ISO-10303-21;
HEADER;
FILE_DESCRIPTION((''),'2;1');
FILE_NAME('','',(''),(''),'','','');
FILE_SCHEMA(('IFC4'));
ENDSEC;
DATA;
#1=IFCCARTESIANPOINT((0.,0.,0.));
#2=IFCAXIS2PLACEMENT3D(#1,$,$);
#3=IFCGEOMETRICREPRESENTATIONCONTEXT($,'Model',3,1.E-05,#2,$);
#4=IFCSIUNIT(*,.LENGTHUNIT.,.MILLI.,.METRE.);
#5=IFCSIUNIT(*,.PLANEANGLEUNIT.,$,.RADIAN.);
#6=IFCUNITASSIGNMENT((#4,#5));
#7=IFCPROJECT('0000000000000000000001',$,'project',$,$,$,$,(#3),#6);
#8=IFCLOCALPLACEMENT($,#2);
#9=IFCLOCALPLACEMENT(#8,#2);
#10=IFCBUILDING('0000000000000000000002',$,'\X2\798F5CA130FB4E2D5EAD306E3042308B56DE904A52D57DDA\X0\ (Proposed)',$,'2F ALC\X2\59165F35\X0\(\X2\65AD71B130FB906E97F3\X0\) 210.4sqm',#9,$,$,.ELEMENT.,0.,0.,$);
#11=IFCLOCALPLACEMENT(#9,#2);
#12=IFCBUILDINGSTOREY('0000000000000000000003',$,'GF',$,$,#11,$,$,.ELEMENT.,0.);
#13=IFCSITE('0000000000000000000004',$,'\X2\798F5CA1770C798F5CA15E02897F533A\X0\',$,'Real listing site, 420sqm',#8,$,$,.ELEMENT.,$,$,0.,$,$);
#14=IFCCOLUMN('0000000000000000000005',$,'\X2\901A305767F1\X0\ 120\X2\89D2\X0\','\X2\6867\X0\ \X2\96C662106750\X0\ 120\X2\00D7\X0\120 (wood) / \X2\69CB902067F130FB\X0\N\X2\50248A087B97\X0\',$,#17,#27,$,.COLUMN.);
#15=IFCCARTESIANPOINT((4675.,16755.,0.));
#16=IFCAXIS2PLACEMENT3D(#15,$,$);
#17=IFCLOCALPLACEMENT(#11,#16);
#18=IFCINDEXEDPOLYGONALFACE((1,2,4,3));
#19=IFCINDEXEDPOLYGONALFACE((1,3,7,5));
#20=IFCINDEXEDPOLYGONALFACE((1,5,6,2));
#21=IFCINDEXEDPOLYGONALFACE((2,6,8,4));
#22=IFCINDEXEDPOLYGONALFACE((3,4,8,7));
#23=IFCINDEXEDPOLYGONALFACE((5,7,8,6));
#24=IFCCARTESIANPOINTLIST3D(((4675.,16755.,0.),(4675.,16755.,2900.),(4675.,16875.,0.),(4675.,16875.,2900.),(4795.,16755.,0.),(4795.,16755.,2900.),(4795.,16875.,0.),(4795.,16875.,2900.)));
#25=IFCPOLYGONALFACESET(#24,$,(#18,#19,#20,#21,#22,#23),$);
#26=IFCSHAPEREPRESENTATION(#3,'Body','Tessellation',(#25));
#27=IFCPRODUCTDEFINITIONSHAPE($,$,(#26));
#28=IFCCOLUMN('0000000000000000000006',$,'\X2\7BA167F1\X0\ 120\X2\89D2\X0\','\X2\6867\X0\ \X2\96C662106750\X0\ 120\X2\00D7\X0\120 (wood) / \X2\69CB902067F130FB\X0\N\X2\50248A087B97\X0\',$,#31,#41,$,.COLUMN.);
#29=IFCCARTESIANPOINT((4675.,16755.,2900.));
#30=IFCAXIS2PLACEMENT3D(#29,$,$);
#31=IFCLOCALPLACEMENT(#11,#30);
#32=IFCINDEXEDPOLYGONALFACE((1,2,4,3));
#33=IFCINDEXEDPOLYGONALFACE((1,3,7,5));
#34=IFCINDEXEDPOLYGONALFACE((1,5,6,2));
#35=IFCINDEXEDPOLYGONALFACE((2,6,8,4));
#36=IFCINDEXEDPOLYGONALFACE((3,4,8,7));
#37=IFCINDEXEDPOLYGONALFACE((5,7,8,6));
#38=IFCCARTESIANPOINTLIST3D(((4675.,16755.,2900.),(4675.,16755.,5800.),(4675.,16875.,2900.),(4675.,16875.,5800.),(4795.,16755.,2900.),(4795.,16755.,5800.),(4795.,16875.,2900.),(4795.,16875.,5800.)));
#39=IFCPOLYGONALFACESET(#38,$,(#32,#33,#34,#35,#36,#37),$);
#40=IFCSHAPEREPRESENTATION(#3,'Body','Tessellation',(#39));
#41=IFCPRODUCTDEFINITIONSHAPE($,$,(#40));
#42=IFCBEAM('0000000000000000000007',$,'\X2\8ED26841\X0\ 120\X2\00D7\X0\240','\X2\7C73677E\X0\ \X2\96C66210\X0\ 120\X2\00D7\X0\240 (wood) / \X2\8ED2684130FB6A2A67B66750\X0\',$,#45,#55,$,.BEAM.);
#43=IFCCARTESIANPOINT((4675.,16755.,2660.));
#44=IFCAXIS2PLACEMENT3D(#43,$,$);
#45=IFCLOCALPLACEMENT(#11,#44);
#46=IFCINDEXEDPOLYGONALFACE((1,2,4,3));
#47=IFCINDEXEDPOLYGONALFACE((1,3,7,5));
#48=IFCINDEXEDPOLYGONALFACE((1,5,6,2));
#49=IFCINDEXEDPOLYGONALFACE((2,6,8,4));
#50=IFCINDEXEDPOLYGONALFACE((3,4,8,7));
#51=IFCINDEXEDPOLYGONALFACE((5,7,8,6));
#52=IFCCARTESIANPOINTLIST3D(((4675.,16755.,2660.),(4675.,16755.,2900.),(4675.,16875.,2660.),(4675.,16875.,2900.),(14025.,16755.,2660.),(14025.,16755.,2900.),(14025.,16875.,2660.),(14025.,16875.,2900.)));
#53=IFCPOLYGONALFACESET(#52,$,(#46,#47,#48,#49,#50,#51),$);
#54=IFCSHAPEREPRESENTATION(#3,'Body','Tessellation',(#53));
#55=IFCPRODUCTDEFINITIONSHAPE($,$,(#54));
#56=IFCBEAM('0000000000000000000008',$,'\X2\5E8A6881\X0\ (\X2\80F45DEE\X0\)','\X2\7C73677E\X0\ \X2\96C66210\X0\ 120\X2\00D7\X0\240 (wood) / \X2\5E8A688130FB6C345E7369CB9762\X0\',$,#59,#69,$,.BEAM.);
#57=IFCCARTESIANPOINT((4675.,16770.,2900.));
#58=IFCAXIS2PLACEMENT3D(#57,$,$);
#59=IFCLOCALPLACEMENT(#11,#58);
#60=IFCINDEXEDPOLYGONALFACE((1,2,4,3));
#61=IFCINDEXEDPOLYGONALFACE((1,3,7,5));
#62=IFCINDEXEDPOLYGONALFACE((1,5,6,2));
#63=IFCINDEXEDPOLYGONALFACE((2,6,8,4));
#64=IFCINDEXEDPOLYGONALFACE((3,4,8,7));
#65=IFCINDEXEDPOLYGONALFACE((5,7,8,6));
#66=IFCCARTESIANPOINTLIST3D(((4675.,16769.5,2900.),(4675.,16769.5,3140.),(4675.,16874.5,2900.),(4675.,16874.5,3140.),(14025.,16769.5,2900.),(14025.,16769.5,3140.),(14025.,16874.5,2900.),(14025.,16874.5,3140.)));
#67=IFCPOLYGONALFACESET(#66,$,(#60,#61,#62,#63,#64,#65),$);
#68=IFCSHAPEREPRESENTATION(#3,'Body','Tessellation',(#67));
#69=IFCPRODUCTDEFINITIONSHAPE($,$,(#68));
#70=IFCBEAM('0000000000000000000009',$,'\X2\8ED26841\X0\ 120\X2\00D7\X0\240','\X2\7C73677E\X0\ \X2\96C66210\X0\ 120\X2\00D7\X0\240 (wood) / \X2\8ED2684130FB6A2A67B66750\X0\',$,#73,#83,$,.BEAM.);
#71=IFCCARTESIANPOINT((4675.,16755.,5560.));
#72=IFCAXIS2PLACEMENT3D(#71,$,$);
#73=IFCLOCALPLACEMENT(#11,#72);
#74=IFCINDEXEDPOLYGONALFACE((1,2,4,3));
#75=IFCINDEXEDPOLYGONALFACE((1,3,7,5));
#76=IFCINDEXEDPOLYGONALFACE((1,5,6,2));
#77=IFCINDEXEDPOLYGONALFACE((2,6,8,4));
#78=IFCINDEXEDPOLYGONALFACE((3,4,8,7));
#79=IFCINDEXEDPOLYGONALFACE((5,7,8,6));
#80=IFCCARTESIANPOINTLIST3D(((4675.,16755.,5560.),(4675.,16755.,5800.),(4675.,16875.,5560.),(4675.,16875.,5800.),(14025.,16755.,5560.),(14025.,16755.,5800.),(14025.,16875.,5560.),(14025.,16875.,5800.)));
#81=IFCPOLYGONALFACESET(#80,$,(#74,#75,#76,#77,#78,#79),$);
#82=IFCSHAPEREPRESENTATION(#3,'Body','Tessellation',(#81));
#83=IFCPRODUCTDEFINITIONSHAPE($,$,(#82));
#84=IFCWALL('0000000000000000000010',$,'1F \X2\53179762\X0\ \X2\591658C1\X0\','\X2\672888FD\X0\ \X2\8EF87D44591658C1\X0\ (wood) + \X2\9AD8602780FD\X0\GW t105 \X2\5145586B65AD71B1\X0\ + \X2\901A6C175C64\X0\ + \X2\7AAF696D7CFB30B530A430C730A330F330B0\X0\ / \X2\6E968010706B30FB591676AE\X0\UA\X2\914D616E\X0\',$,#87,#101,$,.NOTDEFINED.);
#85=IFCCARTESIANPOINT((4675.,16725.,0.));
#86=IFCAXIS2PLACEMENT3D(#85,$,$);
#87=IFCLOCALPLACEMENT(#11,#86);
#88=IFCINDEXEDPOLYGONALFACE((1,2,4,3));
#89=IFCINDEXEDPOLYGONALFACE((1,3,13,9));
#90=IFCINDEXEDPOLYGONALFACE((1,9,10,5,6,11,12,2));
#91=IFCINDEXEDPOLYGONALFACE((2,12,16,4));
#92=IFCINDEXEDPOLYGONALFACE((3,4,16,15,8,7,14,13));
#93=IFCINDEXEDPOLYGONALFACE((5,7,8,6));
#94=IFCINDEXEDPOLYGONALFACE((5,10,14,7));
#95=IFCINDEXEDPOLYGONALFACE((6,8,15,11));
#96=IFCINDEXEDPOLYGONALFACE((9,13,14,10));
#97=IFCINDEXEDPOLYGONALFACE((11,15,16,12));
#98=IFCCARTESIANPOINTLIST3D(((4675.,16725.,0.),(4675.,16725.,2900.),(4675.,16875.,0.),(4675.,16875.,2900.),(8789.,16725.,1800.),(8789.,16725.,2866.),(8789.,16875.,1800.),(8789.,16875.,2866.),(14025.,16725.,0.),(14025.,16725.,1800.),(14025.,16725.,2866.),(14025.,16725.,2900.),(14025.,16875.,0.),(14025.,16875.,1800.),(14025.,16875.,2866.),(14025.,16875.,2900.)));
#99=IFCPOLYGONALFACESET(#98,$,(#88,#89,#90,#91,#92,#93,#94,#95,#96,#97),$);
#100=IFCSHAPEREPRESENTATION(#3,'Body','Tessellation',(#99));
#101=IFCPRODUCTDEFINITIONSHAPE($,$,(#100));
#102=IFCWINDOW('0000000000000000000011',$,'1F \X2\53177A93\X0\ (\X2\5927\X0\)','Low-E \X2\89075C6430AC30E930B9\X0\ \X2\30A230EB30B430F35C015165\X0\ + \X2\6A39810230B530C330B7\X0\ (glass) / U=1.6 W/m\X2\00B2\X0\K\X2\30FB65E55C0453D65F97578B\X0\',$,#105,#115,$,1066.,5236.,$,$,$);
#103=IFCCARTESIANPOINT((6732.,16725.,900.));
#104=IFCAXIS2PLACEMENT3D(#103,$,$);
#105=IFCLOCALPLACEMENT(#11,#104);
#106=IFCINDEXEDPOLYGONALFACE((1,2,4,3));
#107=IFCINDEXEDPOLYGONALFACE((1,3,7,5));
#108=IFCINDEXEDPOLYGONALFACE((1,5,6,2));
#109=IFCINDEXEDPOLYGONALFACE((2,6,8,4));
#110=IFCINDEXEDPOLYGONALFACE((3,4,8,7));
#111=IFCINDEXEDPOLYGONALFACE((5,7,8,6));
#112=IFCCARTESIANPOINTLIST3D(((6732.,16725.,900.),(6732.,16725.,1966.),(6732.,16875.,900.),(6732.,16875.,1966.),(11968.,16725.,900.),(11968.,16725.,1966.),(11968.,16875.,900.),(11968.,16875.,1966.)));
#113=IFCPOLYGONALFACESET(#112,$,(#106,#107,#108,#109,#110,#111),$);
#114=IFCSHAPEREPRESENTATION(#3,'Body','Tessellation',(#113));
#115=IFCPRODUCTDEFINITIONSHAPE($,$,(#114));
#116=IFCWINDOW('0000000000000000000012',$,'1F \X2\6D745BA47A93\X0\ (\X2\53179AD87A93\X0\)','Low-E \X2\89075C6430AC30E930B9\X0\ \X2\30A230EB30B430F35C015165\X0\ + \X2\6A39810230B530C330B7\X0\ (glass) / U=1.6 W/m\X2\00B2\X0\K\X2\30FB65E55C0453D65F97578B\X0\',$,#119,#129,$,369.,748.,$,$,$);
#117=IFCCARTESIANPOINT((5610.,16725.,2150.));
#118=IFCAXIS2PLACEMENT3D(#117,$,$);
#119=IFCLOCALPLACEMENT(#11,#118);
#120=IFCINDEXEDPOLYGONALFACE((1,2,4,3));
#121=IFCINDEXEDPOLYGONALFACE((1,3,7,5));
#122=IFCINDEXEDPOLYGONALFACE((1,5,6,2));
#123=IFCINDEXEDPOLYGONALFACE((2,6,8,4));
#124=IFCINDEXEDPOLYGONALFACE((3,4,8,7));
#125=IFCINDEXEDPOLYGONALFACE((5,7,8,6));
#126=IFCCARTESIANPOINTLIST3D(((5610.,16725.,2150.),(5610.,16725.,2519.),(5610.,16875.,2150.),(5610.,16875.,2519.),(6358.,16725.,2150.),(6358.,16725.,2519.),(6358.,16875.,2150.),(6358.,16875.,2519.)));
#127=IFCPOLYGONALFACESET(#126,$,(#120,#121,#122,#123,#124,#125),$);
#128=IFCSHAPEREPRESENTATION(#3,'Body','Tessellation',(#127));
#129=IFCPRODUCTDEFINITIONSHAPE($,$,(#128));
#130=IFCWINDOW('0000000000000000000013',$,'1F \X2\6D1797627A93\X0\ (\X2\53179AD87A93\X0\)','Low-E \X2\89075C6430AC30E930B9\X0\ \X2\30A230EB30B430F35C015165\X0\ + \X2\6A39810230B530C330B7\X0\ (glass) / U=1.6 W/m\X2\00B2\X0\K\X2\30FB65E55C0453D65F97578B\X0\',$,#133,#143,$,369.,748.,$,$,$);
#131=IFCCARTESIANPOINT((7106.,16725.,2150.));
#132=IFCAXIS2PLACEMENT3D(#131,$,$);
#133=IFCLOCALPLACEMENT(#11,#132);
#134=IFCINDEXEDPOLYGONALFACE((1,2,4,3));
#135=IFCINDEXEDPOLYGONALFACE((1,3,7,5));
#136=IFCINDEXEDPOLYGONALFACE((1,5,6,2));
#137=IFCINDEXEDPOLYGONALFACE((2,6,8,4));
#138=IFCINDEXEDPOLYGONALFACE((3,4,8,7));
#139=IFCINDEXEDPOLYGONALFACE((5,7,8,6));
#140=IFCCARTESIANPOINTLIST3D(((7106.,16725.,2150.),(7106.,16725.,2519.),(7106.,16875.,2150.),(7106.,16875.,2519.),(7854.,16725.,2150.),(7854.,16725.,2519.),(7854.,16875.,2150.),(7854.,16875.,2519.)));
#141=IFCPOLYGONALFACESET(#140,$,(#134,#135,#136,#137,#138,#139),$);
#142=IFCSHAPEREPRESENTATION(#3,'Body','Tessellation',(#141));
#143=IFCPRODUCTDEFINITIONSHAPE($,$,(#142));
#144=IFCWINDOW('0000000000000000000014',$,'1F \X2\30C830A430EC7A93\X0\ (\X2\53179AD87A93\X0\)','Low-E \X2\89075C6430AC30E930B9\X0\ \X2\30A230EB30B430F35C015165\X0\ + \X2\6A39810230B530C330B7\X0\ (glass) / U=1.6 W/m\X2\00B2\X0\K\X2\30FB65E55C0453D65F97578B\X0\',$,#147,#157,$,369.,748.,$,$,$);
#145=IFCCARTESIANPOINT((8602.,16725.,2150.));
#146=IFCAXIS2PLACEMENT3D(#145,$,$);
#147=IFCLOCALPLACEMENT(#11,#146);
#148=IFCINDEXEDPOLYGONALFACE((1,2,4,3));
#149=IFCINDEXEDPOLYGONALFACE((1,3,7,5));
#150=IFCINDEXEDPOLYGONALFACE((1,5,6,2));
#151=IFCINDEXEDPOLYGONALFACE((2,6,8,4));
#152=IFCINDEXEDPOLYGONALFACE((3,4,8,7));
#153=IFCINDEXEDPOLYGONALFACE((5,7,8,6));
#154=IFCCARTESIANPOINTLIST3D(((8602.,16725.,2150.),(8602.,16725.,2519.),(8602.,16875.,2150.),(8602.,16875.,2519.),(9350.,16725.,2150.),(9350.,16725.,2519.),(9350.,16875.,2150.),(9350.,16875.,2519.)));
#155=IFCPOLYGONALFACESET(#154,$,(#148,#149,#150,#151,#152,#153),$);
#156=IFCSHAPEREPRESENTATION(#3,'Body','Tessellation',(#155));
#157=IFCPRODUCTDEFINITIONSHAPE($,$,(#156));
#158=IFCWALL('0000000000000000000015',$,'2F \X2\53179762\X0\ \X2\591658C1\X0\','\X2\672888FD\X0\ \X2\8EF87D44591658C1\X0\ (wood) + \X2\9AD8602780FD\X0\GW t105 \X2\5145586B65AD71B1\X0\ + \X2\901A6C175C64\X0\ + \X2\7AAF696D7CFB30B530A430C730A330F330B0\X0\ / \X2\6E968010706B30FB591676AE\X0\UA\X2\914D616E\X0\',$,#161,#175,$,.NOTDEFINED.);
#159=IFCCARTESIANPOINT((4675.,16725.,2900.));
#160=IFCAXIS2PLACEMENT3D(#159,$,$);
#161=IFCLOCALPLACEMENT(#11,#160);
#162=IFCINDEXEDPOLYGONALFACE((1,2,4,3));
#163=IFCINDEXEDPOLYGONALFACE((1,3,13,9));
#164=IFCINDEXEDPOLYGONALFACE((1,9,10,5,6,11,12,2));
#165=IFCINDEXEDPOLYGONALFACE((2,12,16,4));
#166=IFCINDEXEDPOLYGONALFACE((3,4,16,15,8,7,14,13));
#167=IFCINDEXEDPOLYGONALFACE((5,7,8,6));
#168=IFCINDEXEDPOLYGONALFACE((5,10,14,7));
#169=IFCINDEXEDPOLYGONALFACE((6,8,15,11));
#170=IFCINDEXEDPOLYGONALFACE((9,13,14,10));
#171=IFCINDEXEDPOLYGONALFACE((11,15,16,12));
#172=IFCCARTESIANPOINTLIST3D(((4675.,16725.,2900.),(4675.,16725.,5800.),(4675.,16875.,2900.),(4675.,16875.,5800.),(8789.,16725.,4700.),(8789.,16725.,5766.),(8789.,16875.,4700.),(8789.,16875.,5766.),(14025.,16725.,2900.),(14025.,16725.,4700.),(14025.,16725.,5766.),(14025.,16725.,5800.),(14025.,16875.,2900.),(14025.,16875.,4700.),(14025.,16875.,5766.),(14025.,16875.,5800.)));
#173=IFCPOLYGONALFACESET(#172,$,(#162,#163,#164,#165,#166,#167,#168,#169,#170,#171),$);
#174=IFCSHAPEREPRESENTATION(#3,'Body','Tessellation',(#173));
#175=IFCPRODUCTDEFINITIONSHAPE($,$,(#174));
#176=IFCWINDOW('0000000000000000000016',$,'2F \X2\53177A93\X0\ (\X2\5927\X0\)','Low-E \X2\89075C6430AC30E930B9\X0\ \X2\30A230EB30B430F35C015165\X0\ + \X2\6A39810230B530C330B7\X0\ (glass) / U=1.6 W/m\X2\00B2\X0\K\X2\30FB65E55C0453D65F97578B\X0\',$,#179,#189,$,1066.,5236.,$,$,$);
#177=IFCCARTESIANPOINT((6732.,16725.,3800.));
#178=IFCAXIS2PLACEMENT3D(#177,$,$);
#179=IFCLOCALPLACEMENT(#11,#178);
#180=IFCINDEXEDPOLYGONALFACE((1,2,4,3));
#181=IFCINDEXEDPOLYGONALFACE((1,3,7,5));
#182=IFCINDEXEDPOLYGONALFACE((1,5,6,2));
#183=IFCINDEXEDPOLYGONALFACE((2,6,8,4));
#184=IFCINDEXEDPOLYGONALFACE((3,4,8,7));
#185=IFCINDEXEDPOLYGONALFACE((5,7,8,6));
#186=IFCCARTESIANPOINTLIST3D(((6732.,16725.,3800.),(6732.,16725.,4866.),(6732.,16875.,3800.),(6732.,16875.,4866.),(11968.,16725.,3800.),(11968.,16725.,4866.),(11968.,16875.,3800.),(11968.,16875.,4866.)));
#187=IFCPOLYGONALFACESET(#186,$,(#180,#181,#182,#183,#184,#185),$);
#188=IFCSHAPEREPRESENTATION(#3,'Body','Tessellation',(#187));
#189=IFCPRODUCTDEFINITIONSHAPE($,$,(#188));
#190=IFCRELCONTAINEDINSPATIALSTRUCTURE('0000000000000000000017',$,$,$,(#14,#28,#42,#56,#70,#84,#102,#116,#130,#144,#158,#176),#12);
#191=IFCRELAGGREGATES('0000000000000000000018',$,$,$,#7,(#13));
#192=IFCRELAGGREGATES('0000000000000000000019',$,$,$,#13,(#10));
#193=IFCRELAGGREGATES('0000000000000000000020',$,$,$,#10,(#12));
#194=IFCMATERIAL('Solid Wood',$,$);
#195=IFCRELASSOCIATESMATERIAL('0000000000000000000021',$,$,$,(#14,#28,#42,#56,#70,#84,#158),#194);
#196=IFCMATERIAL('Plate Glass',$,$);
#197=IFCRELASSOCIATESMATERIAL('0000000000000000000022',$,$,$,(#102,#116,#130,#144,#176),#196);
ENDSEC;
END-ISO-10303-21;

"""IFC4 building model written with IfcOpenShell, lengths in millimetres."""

from ifc_helpers import new_model, si_unit, frame, frame_2d, origin, place, context, project, spatial, rectangle, extrude, material, element, fill, save


model = new_model("IFC4")

# Units and contexts
model_context = context("Model", 3, precision=1e-05, world=origin())
ifc_project = project(units=[si_unit("LENGTHUNIT", "METRE", prefix="MILLI"), si_unit("PLANEANGLEUNIT", "RADIAN")], contexts=[model_context])

# Site, building, storey
site_placement = place(None, origin())
site = spatial("IfcSite", under=ifc_project, at=site_placement, Name="福岡県福岡市西区", ObjectType="Real listing site, 420sqm", CompositionType="ELEMENT", RefElevation=0.0)
building_placement = place(site_placement, origin())
building = spatial("IfcBuilding", under=site, at=building_placement, Name="福岡・中庭のある回遊動線 (Proposed)", ObjectType="2F ALC外張(断熱・遮音) 210.4sqm", CompositionType="ELEMENT", ElevationOfRefHeight=0.0, ElevationOfTerrain=0.0)
storey_placement = place(building_placement, origin())
storey = spatial("IfcBuildingStorey", under=building, at=storey_placement, Name="GF", CompositionType="ELEMENT", Elevation=0.0)

# Columns
ifc_material_1 = material(Name="Solid Wood")
column_1_placement = place(storey_placement, frame((4675.0, 16755.0, 0.0)))
element("IfcColumn", 1, at=column_1_placement, inside=storey, material=ifc_material_1, Name="通し柱 120角", Description="桧 集成材 120×120 (wood) / 構造柱・N値計算", PredefinedType="COLUMN", context=model_context, shape_type="SweptSolid", body=[
    extrude(rectangle(XDim=120.0, YDim=120.0, at=frame_2d((60.0, 60.0))), frame((4675.0, 16755.0, 0.0)), (0.0, 0.0, 1.0), 2900.0),
])
column_2_placement = place(storey_placement, frame((4675.0, 16755.0, 2900.0)))
element("IfcColumn", 2, at=column_2_placement, inside=storey, material=ifc_material_1, Name="管柱 120角", Description="桧 集成材 120×120 (wood) / 構造柱・N値計算", PredefinedType="COLUMN", context=model_context, shape_type="SweptSolid", body=[
    extrude(rectangle(XDim=120.0, YDim=120.0, at=frame_2d((60.0, 60.0))), frame((4675.0, 16755.0, 2900.0)), (0.0, 0.0, 1.0), 2900.0),
])

# Beams
beam_1_placement = place(storey_placement, frame((4675.0, 16755.0, 2660.0)))
element("IfcBeam", 3, at=beam_1_placement, inside=storey, material=ifc_material_1, Name="軒桁 120×240", Description="米松 集成 120×240 (wood) / 軒桁・横架材", PredefinedType="BEAM", context=model_context, shape_type="SweptSolid", body=[
    extrude(rectangle(XDim=9350.0, YDim=120.0, at=frame_2d((4675.0, 60.0))), frame((4675.0, 16755.0, 2660.0)), (0.0, 0.0, 1.0), 240.0),
])
beam_2_placement = place(storey_placement, frame((4675.0, 16770.0, 2900.0)))
element("IfcBeam", 4, at=beam_2_placement, inside=storey, material=ifc_material_1, Name="床梁 (胴差)", Description="米松 集成 120×240 (wood) / 床梁・水平構面", PredefinedType="BEAM", context=model_context, shape_type="SweptSolid", body=[
    extrude(rectangle(XDim=9350.0, YDim=105.0, at=frame_2d((4675.0, 52.0))), frame((4675.0, 16770.0, 2900.0)), (0.0, 0.0, 1.0), 240.0),
])
beam_3_placement = place(storey_placement, frame((4675.0, 16755.0, 5560.0)))
element("IfcBeam", 5, at=beam_3_placement, inside=storey, material=ifc_material_1, Name="軒桁 120×240", Description="米松 集成 120×240 (wood) / 軒桁・横架材", PredefinedType="BEAM", context=model_context, shape_type="SweptSolid", body=[
    extrude(rectangle(XDim=9350.0, YDim=120.0, at=frame_2d((4675.0, 60.0))), frame((4675.0, 16755.0, 5560.0)), (0.0, 0.0, 1.0), 240.0),
])

# Wall, openings, windows
wall_1_placement = place(storey_placement, frame((4675.0, 16725.0, 0.0)))
wall_1 = element("IfcWall", 6, at=wall_1_placement, inside=storey, material=ifc_material_1, Name="1F 北面 外壁", Description="木製 軸組外壁 (wood) + 高性能GW t105 充填断熱 + 通気層 + 窯業系サイディング / 準耐火・外皮UA配慮", PredefinedType="NOTDEFINED", context=model_context, shape_type="SweptSolid", body=[
    extrude(rectangle(XDim=9350.0, YDim=150.0, at=frame_2d((4675.0, 75.0))), frame((4675.0, 16725.0, 0.0)), (0.0, 0.0, 1.0), 2900.0),
])
opening_1_placement = place(storey_placement, frame((6732.0, 16725.0, 900.0)))
opening_1 = element("IfcOpeningElement", 7, at=opening_1_placement, cuts=wall_1, PredefinedType="NOTDEFINED", context=model_context, shape_type="SweptSolid", body=[
    extrude(rectangle(XDim=5236.0, YDim=150.0, at=frame_2d((2618.0, 75.0))), frame((6732.0, 16725.0, 900.0)), (0.0, 0.0, 1.0), 1066.0),
])
opening_2_placement = place(storey_placement, frame((5610.0, 16725.0, 2150.0)))
opening_2 = element("IfcOpeningElement", 8, at=opening_2_placement, cuts=wall_1, PredefinedType="NOTDEFINED", context=model_context, shape_type="SweptSolid", body=[
    extrude(rectangle(XDim=748.0, YDim=150.0, at=frame_2d((374.0, 75.0))), frame((5610.0, 16725.0, 2150.0)), (0.0, 0.0, 1.0), 369.0),
])
opening_3_placement = place(storey_placement, frame((7106.0, 16725.0, 2150.0)))
opening_3 = element("IfcOpeningElement", 9, at=opening_3_placement, cuts=wall_1, PredefinedType="NOTDEFINED", context=model_context, shape_type="SweptSolid", body=[
    extrude(rectangle(XDim=748.0, YDim=150.0, at=frame_2d((374.0, 75.0))), frame((7106.0, 16725.0, 2150.0)), (0.0, 0.0, 1.0), 369.0),
])
opening_4_placement = place(storey_placement, frame((8602.0, 16725.0, 2150.0)))
opening_4 = element("IfcOpeningElement", 10, at=opening_4_placement, cuts=wall_1, PredefinedType="NOTDEFINED", context=model_context, shape_type="SweptSolid", body=[
    extrude(rectangle(XDim=748.0, YDim=150.0, at=frame_2d((374.0, 75.0))), frame((8602.0, 16725.0, 2150.0)), (0.0, 0.0, 1.0), 369.0),
])
ifc_material_2 = material(Name="Plate Glass")
window_1_placement = place(storey_placement, frame((6732.0, 16725.0, 900.0)))
window_1 = element("IfcWindow", 11, at=window_1_placement, inside=storey, material=ifc_material_2, Name="1F 北窓 (大)", Description="Low-E 複層ガラス アルゴン封入 + 樹脂サッシ (glass) / U=1.6 W/m²K・日射取得型", OverallHeight=1066.0, OverallWidth=5236.0, context=model_context, shape_type="SweptSolid", body=[
    extrude(rectangle(XDim=5236.0, YDim=150.0, at=frame_2d((2618.0, 75.0))), frame((6732.0, 16725.0, 900.0)), (0.0, 0.0, 1.0), 1066.0),
])
fill(opening_1, window_1)
window_2_placement = place(storey_placement, frame((5610.0, 16725.0, 2150.0)))
window_2 = element("IfcWindow", 12, at=window_2_placement, inside=storey, material=ifc_material_2, Name="1F 浴室窓 (北高窓)", Description="Low-E 複層ガラス アルゴン封入 + 樹脂サッシ (glass) / U=1.6 W/m²K・日射取得型", OverallHeight=369.0, OverallWidth=748.0, context=model_context, shape_type="SweptSolid", body=[
    extrude(rectangle(XDim=748.0, YDim=150.0, at=frame_2d((374.0, 75.0))), frame((5610.0, 16725.0, 2150.0)), (0.0, 0.0, 1.0), 369.0),
])
fill(opening_2, window_2)
window_3_placement = place(storey_placement, frame((7106.0, 16725.0, 2150.0)))
window_3 = element("IfcWindow", 13, at=window_3_placement, inside=storey, material=ifc_material_2, Name="1F 洗面窓 (北高窓)", Description="Low-E 複層ガラス アルゴン封入 + 樹脂サッシ (glass) / U=1.6 W/m²K・日射取得型", OverallHeight=369.0, OverallWidth=748.0, context=model_context, shape_type="SweptSolid", body=[
    extrude(rectangle(XDim=748.0, YDim=150.0, at=frame_2d((374.0, 75.0))), frame((7106.0, 16725.0, 2150.0)), (0.0, 0.0, 1.0), 369.0),
])
fill(opening_3, window_3)
window_4_placement = place(storey_placement, frame((8602.0, 16725.0, 2150.0)))
window_4 = element("IfcWindow", 14, at=window_4_placement, inside=storey, material=ifc_material_2, Name="1F トイレ窓 (北高窓)", Description="Low-E 複層ガラス アルゴン封入 + 樹脂サッシ (glass) / U=1.6 W/m²K・日射取得型", OverallHeight=369.0, OverallWidth=748.0, context=model_context, shape_type="SweptSolid", body=[
    extrude(rectangle(XDim=748.0, YDim=150.0, at=frame_2d((374.0, 75.0))), frame((8602.0, 16725.0, 2150.0)), (0.0, 0.0, 1.0), 369.0),
])
fill(opening_4, window_4)

# Wall, opening, window
wall_2_placement = place(storey_placement, frame((4675.0, 16725.0, 2900.0)))
wall_2 = element("IfcWall", 15, at=wall_2_placement, inside=storey, material=ifc_material_1, Name="2F 北面 外壁", Description="木製 軸組外壁 (wood) + 高性能GW t105 充填断熱 + 通気層 + 窯業系サイディング / 準耐火・外皮UA配慮", PredefinedType="NOTDEFINED", context=model_context, shape_type="SweptSolid", body=[
    extrude(rectangle(XDim=9350.0, YDim=150.0, at=frame_2d((4675.0, 75.0))), frame((4675.0, 16725.0, 2900.0)), (0.0, 0.0, 1.0), 2900.0),
])
opening_5_placement = place(storey_placement, frame((6732.0, 16725.0, 3800.0)))
opening_5 = element("IfcOpeningElement", 16, at=opening_5_placement, cuts=wall_2, PredefinedType="NOTDEFINED", context=model_context, shape_type="SweptSolid", body=[
    extrude(rectangle(XDim=5236.0, YDim=150.0, at=frame_2d((2618.0, 75.0))), frame((6732.0, 16725.0, 3800.0)), (0.0, 0.0, 1.0), 1066.0),
])
window_5_placement = place(storey_placement, frame((6732.0, 16725.0, 3800.0)))
window_5 = element("IfcWindow", 17, at=window_5_placement, inside=storey, material=ifc_material_2, Name="2F 北窓 (大)", Description="Low-E 複層ガラス アルゴン封入 + 樹脂サッシ (glass) / U=1.6 W/m²K・日射取得型", OverallHeight=1066.0, OverallWidth=5236.0, context=model_context, shape_type="SweptSolid", body=[
    extrude(rectangle(XDim=5236.0, YDim=150.0, at=frame_2d((2618.0, 75.0))), frame((6732.0, 16725.0, 3800.0)), (0.0, 0.0, 1.0), 1066.0),
])
fill(opening_5, window_5)

save(model, "model.ifc")
